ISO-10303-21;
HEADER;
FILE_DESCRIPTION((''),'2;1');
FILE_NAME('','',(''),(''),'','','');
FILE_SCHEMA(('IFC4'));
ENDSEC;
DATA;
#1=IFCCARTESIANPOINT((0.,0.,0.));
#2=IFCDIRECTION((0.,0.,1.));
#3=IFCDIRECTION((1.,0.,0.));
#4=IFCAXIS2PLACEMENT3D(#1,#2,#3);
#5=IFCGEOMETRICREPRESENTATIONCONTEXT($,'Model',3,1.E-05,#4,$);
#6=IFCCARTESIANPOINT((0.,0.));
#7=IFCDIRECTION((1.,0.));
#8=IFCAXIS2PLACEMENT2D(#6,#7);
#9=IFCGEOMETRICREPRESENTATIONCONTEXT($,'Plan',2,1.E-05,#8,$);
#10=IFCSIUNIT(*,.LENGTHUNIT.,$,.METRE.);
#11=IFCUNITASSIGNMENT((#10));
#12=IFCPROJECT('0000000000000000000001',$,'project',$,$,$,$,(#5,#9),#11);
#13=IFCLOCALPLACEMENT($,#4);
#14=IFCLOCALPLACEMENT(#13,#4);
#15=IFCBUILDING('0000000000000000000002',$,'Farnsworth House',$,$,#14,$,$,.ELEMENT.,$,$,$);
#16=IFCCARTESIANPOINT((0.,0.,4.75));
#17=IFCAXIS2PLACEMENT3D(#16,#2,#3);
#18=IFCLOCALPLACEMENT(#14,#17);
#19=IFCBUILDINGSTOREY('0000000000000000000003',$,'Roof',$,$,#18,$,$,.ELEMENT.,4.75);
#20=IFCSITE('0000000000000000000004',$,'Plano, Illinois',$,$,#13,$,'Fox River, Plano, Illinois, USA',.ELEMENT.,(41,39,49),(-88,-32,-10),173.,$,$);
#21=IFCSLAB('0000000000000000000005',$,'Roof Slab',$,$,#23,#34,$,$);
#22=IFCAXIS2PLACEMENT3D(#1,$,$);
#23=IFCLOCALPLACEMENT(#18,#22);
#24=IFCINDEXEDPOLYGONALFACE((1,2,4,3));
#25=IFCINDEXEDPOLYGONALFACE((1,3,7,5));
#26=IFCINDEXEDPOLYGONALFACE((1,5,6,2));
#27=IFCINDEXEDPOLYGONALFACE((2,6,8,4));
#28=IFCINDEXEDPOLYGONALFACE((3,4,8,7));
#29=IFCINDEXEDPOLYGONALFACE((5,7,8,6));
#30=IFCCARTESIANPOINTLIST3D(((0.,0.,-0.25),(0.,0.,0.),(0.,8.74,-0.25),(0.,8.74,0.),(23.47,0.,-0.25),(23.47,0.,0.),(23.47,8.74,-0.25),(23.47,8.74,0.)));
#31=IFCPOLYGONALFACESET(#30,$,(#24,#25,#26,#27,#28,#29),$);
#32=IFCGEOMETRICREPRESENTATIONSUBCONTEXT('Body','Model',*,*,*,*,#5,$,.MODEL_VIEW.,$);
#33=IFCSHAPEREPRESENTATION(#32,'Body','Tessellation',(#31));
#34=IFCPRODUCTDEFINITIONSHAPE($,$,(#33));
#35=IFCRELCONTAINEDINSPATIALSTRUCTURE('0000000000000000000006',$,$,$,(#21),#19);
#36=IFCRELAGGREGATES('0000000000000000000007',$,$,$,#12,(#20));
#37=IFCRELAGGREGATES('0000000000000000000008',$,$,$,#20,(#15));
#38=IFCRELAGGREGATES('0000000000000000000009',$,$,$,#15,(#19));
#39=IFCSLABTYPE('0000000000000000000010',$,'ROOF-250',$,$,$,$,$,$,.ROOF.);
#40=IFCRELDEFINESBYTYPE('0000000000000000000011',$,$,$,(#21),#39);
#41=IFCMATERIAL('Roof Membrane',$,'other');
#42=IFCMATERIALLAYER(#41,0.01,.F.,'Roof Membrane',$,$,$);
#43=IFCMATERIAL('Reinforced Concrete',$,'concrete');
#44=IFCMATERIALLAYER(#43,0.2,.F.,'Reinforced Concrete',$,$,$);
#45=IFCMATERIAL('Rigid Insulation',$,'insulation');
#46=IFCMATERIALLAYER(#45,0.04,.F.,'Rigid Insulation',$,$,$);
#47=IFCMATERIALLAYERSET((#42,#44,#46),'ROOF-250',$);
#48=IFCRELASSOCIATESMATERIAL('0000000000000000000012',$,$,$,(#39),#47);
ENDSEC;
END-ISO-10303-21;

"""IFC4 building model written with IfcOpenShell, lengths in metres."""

from ifc_helpers import new_model, si_unit, frame, origin_with_axes, origin_2d_with_axis, place, context, subcontext, project, spatial, rectangle, extrude, material, layer, layer_set, layer_usage, type_object, element, save


model = new_model("IFC4")

# Units and contexts
model_context = context("Model", 3, precision=1e-05, world=origin_with_axes())
plan_context = context("Plan", 2, precision=1e-05, world=origin_2d_with_axis())
body_context = subcontext(model_context, "Body", "Model", "MODEL_VIEW")
ifc_project = project(units=[si_unit("LENGTHUNIT", "METRE")], contexts=[model_context, plan_context])

# Site, building, storey
site_placement = place(None, origin_with_axes())
site = spatial("IfcSite", under=ifc_project, at=site_placement, Name="Plano, Illinois", LongName="Fox River, Plano, Illinois, USA", CompositionType="ELEMENT", RefLatitude=(41, 39, 49), RefLongitude=(-88, -32, -10), RefElevation=173.0)
building_placement = place(site_placement, origin_with_axes())
building = spatial("IfcBuilding", under=site, at=building_placement, Name="Farnsworth House", CompositionType="ELEMENT")
storey_placement = place(building_placement, frame((0.0, 0.0, 4.75), z_axis=(0.0, 0.0, 1.0), x_axis=(1.0, 0.0, 0.0)))
storey = spatial("IfcBuildingStorey", under=building, at=storey_placement, Name="Roof", CompositionType="ELEMENT", Elevation=4.75)

# Slab
ifc_material_1 = material(Name="Roof Membrane", Category="other")
ifc_layer_1 = layer(ifc_material_1, 0.01, ventilated=False, Name="Roof Membrane")
ifc_material_2 = material(Name="Reinforced Concrete", Category="concrete")
ifc_layer_2 = layer(ifc_material_2, 0.2, ventilated=False, Name="Reinforced Concrete")
ifc_material_3 = material(Name="Rigid Insulation", Category="insulation")
ifc_layer_3 = layer(ifc_material_3, 0.04, ventilated=False, Name="Rigid Insulation")
ifc_layer_set = layer_set([ifc_layer_1, ifc_layer_2, ifc_layer_3], Name="ROOF-250")
ifc_layer_usage = layer_usage(ifc_layer_set, "AXIS3", "POSITIVE", -0.25)
slab_type = type_object("IfcSlabType", Name="ROOF-250", PredefinedType="ROOF", material=ifc_layer_usage)
slab_placement = place(storey_placement, frame((0.0, 0.0, -0.25), z_axis=(0.0, 0.0, 1.0), x_axis=(1.0, 0.0, 0.0)))
element("IfcSlab", 1, at=slab_placement, inside=storey, type_object=slab_type, Name="Roof Slab", context=body_context, shape_type="SweptSolid", body=[
    extrude(rectangle(XDim=23.47, YDim=8.74, at=origin_2d_with_axis()), frame((11.735, 4.37, 0.0), z_axis=(0.0, 0.0, 1.0), x_axis=(1.0, 0.0, 0.0)), (0.0, 0.0, 1.0), 0.25),
])

save(model, "model.ifc")
